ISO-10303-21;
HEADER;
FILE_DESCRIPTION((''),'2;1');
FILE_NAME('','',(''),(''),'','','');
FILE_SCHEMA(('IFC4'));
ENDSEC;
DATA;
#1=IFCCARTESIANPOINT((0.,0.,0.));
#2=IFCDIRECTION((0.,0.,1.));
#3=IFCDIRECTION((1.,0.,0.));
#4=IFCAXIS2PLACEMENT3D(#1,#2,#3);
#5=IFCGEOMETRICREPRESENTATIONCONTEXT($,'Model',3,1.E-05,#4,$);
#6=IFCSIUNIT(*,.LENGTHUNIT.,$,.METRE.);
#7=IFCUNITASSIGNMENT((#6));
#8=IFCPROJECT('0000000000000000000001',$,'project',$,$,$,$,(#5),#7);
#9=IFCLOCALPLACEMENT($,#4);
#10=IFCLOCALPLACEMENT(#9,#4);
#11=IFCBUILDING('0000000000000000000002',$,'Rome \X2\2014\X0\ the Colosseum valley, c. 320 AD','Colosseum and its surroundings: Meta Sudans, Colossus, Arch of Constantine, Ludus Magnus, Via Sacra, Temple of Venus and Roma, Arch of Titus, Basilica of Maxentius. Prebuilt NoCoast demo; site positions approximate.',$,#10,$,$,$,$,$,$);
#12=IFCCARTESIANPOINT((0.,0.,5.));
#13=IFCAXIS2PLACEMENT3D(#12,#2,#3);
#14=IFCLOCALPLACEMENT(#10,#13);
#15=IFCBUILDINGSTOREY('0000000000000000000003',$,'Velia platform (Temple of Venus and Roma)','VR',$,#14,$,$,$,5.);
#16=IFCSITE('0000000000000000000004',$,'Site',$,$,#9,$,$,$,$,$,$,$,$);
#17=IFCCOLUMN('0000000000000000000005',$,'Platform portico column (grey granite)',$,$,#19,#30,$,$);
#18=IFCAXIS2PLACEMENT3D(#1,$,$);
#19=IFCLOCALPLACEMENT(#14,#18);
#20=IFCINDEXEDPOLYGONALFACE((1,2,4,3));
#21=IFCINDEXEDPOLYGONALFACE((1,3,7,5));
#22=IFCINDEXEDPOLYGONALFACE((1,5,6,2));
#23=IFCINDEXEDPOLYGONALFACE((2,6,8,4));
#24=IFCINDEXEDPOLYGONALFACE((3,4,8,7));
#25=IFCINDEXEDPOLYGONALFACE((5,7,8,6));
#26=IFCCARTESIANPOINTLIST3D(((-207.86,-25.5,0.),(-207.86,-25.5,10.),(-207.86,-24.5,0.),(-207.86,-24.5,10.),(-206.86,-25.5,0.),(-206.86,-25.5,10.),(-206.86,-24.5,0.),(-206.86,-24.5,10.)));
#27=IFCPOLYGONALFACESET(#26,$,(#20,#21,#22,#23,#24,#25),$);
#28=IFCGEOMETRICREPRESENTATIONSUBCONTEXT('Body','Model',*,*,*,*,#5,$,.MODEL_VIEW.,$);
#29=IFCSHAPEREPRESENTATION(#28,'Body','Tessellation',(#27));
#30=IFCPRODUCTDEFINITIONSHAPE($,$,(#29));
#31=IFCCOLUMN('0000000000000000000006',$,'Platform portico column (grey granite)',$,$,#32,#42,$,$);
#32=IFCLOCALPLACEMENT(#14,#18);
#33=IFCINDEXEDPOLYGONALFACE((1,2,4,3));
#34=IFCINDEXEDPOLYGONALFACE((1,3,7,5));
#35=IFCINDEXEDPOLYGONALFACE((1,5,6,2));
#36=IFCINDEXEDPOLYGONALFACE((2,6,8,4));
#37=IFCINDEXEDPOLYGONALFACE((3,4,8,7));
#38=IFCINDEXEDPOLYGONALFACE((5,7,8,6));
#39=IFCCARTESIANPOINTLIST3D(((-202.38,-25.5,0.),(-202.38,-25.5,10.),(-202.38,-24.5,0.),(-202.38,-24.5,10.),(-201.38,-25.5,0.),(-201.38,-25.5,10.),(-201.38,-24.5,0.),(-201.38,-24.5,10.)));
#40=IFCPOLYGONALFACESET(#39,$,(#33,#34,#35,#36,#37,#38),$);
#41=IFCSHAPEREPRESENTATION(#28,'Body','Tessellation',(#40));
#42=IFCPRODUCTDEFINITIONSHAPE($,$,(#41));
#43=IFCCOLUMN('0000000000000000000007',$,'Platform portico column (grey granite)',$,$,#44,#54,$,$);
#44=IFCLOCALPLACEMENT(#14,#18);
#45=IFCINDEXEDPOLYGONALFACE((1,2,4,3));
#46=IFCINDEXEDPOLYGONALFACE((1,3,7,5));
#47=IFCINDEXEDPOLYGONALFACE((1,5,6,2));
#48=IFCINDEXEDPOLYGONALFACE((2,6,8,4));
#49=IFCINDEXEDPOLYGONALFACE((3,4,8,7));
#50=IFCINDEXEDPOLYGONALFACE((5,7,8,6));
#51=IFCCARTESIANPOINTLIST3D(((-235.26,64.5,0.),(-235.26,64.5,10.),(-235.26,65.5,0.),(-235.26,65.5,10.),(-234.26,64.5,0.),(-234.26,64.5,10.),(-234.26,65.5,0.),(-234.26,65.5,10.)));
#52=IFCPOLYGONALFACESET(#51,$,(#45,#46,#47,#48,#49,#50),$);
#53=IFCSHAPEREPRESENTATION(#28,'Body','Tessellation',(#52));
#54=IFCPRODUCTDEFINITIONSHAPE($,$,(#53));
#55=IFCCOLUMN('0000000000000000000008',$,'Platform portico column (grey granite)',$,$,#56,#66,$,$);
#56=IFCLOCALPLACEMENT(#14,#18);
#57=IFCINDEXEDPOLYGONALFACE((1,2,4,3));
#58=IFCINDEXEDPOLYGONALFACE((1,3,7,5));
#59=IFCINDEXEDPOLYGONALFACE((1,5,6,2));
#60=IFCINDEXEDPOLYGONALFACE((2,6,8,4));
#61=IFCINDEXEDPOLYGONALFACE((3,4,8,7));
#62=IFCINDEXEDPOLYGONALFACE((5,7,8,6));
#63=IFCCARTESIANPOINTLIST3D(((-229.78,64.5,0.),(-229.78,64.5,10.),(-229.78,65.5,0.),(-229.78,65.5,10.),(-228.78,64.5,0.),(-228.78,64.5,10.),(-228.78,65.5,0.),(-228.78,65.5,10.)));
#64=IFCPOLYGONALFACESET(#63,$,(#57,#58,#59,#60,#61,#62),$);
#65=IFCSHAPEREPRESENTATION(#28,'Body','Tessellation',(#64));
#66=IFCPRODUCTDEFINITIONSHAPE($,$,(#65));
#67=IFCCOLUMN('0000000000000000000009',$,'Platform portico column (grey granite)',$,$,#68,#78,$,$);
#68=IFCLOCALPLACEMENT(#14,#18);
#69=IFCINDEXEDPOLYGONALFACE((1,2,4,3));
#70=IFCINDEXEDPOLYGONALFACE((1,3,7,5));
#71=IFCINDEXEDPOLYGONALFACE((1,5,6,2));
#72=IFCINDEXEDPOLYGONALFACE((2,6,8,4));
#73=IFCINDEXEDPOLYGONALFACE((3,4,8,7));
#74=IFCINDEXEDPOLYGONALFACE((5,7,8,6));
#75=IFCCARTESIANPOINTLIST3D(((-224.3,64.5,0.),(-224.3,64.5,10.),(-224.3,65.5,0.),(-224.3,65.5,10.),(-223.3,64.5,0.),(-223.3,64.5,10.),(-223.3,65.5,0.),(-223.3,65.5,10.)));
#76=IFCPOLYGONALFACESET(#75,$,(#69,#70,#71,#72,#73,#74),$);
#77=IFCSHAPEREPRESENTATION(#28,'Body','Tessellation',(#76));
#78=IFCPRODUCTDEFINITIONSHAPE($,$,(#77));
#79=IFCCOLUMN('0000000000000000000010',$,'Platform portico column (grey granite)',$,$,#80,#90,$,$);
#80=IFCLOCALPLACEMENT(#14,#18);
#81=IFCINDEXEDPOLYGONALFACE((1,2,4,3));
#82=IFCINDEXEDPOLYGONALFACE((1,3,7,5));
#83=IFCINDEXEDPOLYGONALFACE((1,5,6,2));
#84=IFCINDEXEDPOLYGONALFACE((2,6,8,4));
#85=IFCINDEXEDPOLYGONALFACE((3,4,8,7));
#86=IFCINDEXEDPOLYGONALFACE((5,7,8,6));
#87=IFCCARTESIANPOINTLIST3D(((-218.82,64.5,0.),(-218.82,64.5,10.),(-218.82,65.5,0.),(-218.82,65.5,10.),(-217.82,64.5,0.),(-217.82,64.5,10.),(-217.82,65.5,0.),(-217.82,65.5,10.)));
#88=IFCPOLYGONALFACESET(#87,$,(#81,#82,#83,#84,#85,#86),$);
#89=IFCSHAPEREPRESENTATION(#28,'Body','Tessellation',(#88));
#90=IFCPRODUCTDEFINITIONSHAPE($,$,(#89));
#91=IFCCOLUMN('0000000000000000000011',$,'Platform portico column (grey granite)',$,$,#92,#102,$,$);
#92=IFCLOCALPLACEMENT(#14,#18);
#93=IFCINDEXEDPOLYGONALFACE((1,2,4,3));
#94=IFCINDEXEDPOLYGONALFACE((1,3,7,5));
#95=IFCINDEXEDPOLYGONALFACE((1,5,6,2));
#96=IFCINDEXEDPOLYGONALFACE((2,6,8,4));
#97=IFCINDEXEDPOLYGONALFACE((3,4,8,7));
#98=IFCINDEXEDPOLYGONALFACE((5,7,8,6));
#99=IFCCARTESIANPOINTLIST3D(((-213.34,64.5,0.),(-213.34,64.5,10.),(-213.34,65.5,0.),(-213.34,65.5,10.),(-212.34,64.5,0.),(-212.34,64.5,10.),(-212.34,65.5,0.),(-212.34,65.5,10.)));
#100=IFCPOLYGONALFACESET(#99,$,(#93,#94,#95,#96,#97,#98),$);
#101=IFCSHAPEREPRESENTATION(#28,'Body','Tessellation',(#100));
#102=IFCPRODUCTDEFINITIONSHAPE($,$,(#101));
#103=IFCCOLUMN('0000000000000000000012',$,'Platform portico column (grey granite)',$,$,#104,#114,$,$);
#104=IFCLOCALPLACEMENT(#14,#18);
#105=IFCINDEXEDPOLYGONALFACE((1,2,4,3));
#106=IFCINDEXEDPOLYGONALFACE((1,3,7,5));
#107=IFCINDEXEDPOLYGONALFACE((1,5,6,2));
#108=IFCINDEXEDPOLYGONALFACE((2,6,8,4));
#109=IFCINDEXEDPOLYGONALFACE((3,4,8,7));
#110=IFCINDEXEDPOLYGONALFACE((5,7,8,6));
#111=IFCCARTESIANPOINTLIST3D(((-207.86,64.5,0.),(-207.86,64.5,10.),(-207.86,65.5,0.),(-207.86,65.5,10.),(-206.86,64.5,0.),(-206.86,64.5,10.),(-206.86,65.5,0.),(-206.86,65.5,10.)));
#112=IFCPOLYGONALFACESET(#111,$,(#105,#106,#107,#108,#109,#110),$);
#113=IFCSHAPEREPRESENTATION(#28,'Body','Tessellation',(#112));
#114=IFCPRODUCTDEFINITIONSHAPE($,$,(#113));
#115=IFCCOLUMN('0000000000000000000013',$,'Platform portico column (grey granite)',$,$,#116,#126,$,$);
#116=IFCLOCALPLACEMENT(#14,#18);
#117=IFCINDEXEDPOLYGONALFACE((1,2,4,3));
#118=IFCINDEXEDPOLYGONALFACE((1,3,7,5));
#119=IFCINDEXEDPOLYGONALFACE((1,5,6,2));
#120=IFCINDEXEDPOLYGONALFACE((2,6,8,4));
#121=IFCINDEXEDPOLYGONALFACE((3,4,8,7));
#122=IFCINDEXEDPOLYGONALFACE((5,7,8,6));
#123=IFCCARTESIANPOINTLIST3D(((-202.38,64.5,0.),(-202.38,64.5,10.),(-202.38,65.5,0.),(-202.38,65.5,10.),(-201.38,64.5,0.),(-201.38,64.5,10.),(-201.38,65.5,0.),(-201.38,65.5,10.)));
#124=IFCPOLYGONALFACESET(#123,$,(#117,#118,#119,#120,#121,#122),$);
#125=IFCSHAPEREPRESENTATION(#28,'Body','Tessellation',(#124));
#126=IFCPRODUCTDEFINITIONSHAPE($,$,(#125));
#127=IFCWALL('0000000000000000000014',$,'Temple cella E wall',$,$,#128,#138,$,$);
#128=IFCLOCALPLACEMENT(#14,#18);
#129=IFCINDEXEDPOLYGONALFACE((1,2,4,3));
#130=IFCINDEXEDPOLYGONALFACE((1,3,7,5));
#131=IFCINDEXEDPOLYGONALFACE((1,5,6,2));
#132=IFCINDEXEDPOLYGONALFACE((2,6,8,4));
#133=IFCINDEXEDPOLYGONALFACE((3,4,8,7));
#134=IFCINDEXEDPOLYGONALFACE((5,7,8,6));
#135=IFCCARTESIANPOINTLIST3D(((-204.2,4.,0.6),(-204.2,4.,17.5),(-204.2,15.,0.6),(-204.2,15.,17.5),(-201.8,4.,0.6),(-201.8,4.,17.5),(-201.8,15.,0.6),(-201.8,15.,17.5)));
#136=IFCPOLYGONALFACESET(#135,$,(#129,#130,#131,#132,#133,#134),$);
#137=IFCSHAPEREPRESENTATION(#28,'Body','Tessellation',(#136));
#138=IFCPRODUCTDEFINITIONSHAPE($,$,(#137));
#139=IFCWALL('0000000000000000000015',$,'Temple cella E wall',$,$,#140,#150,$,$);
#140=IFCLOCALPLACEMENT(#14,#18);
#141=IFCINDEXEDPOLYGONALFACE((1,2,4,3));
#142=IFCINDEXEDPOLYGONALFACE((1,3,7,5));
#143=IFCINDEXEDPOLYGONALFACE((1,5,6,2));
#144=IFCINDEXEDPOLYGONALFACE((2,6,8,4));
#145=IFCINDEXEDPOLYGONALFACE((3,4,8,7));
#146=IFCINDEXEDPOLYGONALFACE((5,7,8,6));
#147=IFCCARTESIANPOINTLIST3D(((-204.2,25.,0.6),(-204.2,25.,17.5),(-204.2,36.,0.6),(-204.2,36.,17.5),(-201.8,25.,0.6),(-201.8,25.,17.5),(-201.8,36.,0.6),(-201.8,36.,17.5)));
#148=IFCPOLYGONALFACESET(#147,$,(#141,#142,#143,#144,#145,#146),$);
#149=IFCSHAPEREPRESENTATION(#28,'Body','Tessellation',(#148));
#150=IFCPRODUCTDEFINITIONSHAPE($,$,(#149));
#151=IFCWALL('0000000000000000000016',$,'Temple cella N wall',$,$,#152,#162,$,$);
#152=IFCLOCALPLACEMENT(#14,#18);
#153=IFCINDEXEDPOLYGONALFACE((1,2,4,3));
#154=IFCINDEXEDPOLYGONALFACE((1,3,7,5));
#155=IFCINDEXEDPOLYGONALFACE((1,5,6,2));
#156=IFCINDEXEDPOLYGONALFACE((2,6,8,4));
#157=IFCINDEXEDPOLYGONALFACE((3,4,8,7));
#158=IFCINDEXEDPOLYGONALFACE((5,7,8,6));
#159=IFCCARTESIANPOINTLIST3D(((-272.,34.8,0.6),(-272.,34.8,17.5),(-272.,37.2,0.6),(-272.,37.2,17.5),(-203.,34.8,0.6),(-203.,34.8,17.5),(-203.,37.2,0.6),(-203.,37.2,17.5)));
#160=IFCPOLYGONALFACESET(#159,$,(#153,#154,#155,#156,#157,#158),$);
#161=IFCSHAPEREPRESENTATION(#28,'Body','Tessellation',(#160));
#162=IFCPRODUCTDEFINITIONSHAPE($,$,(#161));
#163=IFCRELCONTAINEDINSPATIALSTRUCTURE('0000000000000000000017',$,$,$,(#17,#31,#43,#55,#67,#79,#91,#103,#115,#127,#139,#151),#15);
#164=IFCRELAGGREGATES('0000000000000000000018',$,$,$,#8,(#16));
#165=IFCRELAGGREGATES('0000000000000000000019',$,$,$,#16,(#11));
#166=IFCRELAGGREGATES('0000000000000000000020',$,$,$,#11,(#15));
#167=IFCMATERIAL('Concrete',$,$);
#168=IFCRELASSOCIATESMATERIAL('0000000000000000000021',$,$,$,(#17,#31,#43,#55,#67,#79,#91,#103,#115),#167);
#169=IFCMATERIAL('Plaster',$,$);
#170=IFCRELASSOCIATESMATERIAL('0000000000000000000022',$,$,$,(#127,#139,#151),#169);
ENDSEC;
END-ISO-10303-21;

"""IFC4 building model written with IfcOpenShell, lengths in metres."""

from ifc_helpers import new_model, si_unit, frame, origin_with_axes, place, context, subcontext, project, spatial, indexed_curve, outline, extrude, material, element, save


model = new_model("IFC4")

# Units and contexts
model_context = context("Model", 3, precision=1e-05, world=origin_with_axes())
body_context = subcontext(model_context, "Body", "Model", "MODEL_VIEW")
ifc_project = project(units=[si_unit("LENGTHUNIT", "METRE")], contexts=[model_context])

# Site, building, storey
site_placement = place(None, origin_with_axes())
site = spatial("IfcSite", under=ifc_project, at=site_placement, Name="Site")
building_placement = place(site_placement, origin_with_axes())
building = spatial("IfcBuilding", under=site, at=building_placement, Name="Rome — the Colosseum valley, c. 320 AD", Description="Colosseum and its surroundings: Meta Sudans, Colossus, Arch of Constantine, Ludus Magnus, Via Sacra, Temple of Venus and Roma, Arch of Titus, Basilica of Maxentius. Prebuilt NoCoast demo; site positions approximate.")
storey_placement = place(building_placement, frame((0.0, 0.0, 5.0), z_axis=(0.0, 0.0, 1.0), x_axis=(1.0, 0.0, 0.0)))
storey = spatial("IfcBuildingStorey", under=building, at=storey_placement, Name="Velia platform (Temple of Venus and Roma)", Description="VR", Elevation=5.0)

# Columns
ifc_material_1 = material(Name="Concrete")
for number, where, z_axis, x_axis, name in (
    (1, (-207.86, -25.0, 0.0), (0.0, 0.0, 1.0), (1.0, 0.0, 0.0), "Platform portico column (grey granite)"),
    (2, (-202.38, -25.0, 0.0), (0.0, 0.0, 1.0), (1.0, 0.0, 0.0), "Platform portico column (grey granite)"),
    (3, (-235.26, 65.0, 0.0), (0.0, 0.0, 1.0), (1.0, 0.0, 0.0), "Platform portico column (grey granite)"),
    (4, (-229.78, 65.0, 0.0), (0.0, 0.0, 1.0), (1.0, 0.0, 0.0), "Platform portico column (grey granite)"),
    (5, (-224.3, 65.0, 0.0), (0.0, 0.0, 1.0), (1.0, 0.0, 0.0), "Platform portico column (grey granite)"),
    (6, (-218.82, 65.0, 0.0), (0.0, 0.0, 1.0), (1.0, 0.0, 0.0), "Platform portico column (grey granite)"),
    (7, (-213.34, 65.0, 0.0), (0.0, 0.0, 1.0), (1.0, 0.0, 0.0), "Platform portico column (grey granite)"),
    (8, (-207.86, 65.0, 0.0), (0.0, 0.0, 1.0), (1.0, 0.0, 0.0), "Platform portico column (grey granite)"),
    (9, (-202.38, 65.0, 0.0), (0.0, 0.0, 1.0), (1.0, 0.0, 0.0), "Platform portico column (grey granite)"),
):
    element("IfcColumn", number, at=place(storey_placement, frame(where, z_axis=z_axis, x_axis=x_axis)), inside=storey, material=ifc_material_1, Name=name, context=body_context, shape_type="SweptSolid", body=[
        extrude(outline(indexed_curve([(0.0, 0.0), (0.0, 1.0), (1.0, 1.0), (1.0, 0.0), (0.0, 0.0)], self_intersect=False)), frame((0.0, -0.5, 0.0), z_axis=(0.0, 0.0, 1.0), x_axis=(1.0, 0.0, 0.0)), (0.0, 0.0, 1.0), 10.0),
    ])

# Walls
ifc_material_2 = material(Name="Plaster")
for number, where, z_axis, x_axis, name in (
    (10, (-203.0, 4.0, 0.6), (0.0, 0.0, 1.0), (0.0, 1.0, 0.0), "Temple cella E wall"),
    (11, (-203.0, 25.0, 0.6), (0.0, 0.0, 1.0), (0.0, 1.0, 0.0), "Temple cella E wall"),
):
    element("IfcWall", number, at=place(storey_placement, frame(where, z_axis=z_axis, x_axis=x_axis)), inside=storey, material=ifc_material_2, Name=name, context=body_context, shape_type="SweptSolid", body=[
        extrude(outline(indexed_curve([(0.0, 0.0), (0.0, 2.4), (11.0, 2.4), (11.0, 0.0), (0.0, 0.0)], self_intersect=False)), frame((0.0, -1.2, 0.0), z_axis=(0.0, 0.0, 1.0), x_axis=(1.0, 0.0, 0.0)), (0.0, 0.0, 1.0), 16.9),
    ])
wall_placement = place(storey_placement, frame((-203.0, 36.0, 0.6), z_axis=(0.0, 0.0, 1.0), x_axis=(-1.0, 0.0, 0.0)))
element("IfcWall", 12, at=wall_placement, inside=storey, material=ifc_material_2, Name="Temple cella N wall", context=body_context, shape_type="SweptSolid", body=[
    extrude(outline(indexed_curve([(0.0, 0.0), (0.0, 2.4), (69.0, 2.4), (69.0, 0.0), (0.0, 0.0)], self_intersect=False)), frame((0.0, -1.2, 0.0), z_axis=(0.0, 0.0, 1.0), x_axis=(1.0, 0.0, 0.0)), (0.0, 0.0, 1.0), 16.9),
])

save(model, "model.ifc")
